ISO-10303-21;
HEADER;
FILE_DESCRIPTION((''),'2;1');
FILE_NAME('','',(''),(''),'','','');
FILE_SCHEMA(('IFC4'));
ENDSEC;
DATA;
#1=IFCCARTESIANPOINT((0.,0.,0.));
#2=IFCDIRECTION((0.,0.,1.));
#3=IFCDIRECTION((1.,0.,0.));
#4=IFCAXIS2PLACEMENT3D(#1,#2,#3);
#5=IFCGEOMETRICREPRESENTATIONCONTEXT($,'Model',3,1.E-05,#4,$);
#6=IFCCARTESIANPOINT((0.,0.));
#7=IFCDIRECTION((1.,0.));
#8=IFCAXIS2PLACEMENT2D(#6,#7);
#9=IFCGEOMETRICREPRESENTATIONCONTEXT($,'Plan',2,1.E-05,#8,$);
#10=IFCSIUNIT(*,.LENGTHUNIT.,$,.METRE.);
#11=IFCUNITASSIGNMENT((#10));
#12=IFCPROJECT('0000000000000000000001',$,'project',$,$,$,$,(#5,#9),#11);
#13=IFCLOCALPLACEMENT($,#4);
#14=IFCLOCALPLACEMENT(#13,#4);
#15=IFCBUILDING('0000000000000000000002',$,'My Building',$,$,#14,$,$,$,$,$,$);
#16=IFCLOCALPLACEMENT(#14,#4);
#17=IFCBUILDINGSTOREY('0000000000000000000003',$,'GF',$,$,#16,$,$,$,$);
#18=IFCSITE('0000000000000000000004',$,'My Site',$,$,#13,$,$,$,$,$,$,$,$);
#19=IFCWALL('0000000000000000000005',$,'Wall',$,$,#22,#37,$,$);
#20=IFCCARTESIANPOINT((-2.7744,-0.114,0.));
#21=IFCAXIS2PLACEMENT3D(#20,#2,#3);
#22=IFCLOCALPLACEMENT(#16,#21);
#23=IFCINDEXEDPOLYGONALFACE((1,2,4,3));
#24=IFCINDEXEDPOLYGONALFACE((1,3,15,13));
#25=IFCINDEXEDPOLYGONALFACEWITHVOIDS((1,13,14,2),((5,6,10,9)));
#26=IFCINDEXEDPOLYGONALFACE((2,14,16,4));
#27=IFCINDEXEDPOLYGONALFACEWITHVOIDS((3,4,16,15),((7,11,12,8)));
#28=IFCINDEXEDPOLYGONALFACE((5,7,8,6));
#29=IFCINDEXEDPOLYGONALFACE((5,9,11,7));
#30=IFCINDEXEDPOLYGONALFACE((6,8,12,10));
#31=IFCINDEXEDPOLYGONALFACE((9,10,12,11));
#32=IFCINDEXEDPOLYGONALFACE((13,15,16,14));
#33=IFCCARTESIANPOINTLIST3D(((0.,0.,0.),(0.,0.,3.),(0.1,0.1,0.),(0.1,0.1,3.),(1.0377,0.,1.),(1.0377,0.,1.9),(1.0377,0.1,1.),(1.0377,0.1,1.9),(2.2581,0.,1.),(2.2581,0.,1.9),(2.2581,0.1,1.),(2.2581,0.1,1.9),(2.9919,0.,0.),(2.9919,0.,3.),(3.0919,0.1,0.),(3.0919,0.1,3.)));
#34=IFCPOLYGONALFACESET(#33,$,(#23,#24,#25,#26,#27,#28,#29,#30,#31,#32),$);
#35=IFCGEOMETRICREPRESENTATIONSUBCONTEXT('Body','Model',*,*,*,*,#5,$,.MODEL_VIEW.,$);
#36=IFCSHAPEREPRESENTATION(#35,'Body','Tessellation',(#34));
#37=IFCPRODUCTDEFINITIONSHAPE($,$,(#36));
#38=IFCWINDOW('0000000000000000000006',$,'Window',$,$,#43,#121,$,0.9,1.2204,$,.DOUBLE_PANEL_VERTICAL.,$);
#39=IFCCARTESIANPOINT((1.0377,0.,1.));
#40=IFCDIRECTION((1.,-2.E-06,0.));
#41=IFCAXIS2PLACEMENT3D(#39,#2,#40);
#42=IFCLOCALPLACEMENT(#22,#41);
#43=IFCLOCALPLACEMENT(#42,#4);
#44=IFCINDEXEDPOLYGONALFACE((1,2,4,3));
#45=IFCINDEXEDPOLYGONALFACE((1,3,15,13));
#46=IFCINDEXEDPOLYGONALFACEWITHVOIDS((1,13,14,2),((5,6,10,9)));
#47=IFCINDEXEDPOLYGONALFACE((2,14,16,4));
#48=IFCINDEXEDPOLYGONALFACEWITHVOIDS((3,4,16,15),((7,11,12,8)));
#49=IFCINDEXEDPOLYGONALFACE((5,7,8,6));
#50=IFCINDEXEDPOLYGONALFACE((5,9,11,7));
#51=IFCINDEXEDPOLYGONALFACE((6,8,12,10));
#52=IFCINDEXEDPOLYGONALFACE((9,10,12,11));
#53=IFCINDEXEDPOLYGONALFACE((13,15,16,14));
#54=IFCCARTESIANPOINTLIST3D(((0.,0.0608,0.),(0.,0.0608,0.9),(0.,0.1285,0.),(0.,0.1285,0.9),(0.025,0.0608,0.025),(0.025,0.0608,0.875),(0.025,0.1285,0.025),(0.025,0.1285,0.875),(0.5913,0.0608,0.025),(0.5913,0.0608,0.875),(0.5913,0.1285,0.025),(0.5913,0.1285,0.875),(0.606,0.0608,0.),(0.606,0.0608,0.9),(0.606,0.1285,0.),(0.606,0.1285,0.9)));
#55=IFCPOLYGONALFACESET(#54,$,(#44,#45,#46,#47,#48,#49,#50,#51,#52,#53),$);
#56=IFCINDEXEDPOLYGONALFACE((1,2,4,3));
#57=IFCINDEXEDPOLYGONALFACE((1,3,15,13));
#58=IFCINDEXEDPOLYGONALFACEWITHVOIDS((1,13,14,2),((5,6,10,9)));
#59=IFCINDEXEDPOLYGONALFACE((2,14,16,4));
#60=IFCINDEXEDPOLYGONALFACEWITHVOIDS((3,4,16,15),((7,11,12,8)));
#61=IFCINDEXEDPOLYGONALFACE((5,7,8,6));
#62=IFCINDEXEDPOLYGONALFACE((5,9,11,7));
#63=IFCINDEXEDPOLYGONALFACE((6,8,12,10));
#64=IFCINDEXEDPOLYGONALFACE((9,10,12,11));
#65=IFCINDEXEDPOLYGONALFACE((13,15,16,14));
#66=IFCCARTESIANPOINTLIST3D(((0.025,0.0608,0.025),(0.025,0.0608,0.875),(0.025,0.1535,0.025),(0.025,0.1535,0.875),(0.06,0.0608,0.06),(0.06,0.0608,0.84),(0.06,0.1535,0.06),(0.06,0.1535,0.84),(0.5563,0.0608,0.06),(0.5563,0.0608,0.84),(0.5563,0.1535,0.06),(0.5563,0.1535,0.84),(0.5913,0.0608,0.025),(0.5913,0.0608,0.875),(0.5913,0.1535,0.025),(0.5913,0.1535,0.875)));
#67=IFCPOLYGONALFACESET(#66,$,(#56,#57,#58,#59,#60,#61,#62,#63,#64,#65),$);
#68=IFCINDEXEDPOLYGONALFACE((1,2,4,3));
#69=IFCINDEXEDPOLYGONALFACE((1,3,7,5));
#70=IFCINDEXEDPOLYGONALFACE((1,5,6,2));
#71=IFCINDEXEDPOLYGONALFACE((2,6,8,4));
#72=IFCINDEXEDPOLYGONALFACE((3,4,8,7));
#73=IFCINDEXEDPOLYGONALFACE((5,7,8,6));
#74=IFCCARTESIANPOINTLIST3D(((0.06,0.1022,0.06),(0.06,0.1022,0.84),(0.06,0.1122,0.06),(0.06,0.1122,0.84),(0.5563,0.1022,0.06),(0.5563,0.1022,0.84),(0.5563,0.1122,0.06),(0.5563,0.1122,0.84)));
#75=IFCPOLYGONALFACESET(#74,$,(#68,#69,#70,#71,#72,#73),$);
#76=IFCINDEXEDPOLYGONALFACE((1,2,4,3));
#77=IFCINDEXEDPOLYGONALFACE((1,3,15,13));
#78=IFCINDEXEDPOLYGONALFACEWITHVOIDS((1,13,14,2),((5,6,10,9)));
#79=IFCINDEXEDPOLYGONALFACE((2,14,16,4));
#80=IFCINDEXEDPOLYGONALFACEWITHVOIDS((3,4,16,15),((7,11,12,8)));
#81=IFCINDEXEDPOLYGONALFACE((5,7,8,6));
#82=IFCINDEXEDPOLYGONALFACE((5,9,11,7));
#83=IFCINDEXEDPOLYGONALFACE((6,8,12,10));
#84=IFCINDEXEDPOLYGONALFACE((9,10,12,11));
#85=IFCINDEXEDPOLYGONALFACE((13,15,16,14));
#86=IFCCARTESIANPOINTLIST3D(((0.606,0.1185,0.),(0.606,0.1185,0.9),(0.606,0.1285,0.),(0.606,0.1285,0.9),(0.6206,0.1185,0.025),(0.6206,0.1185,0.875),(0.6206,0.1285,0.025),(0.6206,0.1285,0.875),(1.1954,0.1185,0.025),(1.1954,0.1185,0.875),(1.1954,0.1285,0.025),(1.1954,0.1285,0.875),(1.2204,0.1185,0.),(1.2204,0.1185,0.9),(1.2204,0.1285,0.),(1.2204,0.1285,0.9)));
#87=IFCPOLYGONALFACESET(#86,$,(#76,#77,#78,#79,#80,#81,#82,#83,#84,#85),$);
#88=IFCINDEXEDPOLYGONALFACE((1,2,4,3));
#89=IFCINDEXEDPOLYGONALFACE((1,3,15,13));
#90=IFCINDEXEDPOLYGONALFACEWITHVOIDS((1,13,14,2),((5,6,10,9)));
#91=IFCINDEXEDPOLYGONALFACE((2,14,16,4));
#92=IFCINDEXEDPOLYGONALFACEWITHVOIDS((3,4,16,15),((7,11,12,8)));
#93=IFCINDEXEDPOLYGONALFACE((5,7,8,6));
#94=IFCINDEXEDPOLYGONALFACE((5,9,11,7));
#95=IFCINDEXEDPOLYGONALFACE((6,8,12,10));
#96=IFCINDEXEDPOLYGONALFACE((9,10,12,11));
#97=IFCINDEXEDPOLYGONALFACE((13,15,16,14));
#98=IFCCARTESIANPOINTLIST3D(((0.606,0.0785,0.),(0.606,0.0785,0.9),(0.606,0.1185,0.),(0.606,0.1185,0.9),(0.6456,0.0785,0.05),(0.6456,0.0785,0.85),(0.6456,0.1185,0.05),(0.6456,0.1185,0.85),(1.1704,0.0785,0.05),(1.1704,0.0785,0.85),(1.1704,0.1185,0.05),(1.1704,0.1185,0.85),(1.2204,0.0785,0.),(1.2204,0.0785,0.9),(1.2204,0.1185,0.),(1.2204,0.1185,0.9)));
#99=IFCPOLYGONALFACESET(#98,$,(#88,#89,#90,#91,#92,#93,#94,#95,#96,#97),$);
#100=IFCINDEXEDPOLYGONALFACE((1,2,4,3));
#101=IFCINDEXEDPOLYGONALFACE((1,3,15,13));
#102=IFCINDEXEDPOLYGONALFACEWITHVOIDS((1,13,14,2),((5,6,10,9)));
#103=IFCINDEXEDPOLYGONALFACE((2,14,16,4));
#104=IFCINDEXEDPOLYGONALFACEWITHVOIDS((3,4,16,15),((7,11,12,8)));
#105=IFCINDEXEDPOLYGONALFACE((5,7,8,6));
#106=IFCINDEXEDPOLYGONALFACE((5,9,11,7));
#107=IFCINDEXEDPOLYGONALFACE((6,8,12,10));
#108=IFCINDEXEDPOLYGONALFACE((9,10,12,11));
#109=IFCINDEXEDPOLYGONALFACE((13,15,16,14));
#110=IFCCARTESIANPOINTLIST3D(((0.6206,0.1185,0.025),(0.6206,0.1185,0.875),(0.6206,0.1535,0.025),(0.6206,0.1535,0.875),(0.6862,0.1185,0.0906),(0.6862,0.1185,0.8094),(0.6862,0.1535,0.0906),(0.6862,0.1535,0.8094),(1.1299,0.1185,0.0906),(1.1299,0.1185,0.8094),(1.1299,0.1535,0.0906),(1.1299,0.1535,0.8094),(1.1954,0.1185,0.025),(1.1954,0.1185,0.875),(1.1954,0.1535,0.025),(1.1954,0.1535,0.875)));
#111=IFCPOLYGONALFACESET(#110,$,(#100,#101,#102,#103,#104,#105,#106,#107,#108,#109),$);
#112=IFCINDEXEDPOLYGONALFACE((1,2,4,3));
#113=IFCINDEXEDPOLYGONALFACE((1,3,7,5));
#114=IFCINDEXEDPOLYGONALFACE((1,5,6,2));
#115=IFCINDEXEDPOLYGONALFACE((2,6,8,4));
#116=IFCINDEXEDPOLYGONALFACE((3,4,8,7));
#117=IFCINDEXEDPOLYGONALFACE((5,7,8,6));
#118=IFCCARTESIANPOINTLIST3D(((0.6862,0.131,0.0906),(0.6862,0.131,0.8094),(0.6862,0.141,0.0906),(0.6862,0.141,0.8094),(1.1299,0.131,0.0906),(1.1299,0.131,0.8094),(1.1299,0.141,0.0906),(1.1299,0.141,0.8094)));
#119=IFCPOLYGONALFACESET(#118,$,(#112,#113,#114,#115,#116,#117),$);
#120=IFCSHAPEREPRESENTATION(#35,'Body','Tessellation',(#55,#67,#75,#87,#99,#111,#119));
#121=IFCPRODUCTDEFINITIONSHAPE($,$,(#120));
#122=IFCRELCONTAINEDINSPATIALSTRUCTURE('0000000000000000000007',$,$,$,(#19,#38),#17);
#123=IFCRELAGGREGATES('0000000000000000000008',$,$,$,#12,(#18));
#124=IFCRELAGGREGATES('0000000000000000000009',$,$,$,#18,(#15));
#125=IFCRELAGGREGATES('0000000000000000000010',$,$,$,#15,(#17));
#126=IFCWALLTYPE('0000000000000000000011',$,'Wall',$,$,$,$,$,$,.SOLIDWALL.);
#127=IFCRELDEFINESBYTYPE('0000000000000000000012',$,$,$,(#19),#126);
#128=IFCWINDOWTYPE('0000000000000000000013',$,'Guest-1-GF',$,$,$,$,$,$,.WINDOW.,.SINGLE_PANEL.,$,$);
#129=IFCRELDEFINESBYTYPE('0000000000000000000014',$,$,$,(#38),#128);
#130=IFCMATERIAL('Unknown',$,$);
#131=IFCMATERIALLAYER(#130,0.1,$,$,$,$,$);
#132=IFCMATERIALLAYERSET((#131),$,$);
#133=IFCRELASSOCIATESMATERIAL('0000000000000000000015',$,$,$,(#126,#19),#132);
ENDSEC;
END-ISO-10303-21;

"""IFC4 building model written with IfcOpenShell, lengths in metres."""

from ifc_helpers import new_model, entity, si_unit, frame, origin_with_axes, origin_2d_with_axis, place, context, subcontext, project, spatial, line, indexed_curve, outline, extrude, shape, source, transform, mapped, material, layer, layer_set, layer_usage, type_object, type_shapes, element, fill, save


model = new_model("IFC4")

# Units and contexts
model_context = context("Model", 3, precision=1e-05, world=origin_with_axes())
plan_context = context("Plan", 2, precision=1e-05, world=origin_2d_with_axis())
body_context_1 = subcontext(model_context, "Body", "Model", "MODEL_VIEW")
body_context_2 = subcontext(plan_context, "Body", "Plan", "PLAN_VIEW")
ifc_project = project(units=[si_unit("LENGTHUNIT", "METRE")], contexts=[model_context, plan_context])

# Site, building, storey
site_placement = place(None, origin_with_axes())
site = spatial("IfcSite", under=ifc_project, at=site_placement, Name="My Site")
building_placement = place(site_placement, origin_with_axes())
building = spatial("IfcBuilding", under=site, at=building_placement, Name="My Building")
storey_placement = place(building_placement, origin_with_axes())
storey = spatial("IfcBuildingStorey", under=building, at=storey_placement, Name="GF")

# Shared definitions
ifc_material = material(Name="Unknown")

# Shared definitions
ifc_layer_1 = layer(ifc_material, 0.1)
ifc_layer_set_1 = layer_set([ifc_layer_1])
wall_type = type_object("IfcWallType", Name="Wall", PredefinedType="SOLIDWALL", material=ifc_layer_set_1)

# Wall, opening, window
ifc_layer_usage_1 = layer_usage(ifc_layer_set_1, "AXIS2", "POSITIVE", 0.0)
wall_1_placement = place(storey_placement, frame((-2.7744, -0.114, 0.0), z_axis=(0.0, 0.0, 1.0), x_axis=(1.0, 0.0, 0.0)))
wall_1 = element("IfcWall", 1, at=wall_1_placement, inside=storey, type_object=wall_type, material=ifc_layer_usage_1, Name="Wall", context=body_context_1, shape_type="SweptSolid", body=[
    extrude(outline(indexed_curve([(0.0, 0.0), (0.1, 0.1), (3.0919, 0.1), (2.9919, 0.0)], segments=[line(1, 2, 3, 4, 1)])), origin_with_axes(), (0.0, 0.0, 1.0), 3.0),
])
shared_shape_1 = source(origin_with_axes(), body_context_1, "Body", "SweptSolid", [
    extrude(outline(indexed_curve([(0.0, 0.0), (1.2204, 0.0), (1.2204, 0.9), (0.0, 0.9)], segments=[line(1, 2, 3, 4, 1)])), frame((0.0, -0.6, 0.0), z_axis=(0.0, -1.0, 0.0), x_axis=(1.0, 0.0, 0.0)), (0.0, 0.0, -1.0), 1.2),
])
opening_1_placement = place(wall_1_placement, frame((1.0377, 0.0, 1.0), z_axis=(0.0, 0.0, 1.0), x_axis=(1.0, -0.000002, 0.0)))
opening_1 = element("IfcOpeningElement", 2, at=opening_1_placement, cuts=wall_1, PredefinedType="OPENING", context=body_context_1, shape_type="MappedRepresentation", body=[
    mapped(shared_shape_1, transform((0.0, 0.0, 0.0), x_axis=(1.0, 0.0, 0.0), y_axis=(0.0, 1.0, 0.0), z_axis=(0.0, 0.0, 1.0), scale=1.0)),
])
window_type_1 = type_object("IfcWindowType", Name="Guest-1-GF", PartitioningType="SINGLE_PANEL", PredefinedType="WINDOW")
shared_shape_2 = source(origin_with_axes(), body_context_1, "Body", "SweptSolid", [
    extrude(outline(indexed_curve([(0.0, 0.0), (0.606, 0.0), (0.606, 0.9), (0.0, 0.9)], segments=[line(1, 2, 3, 4, 1)]), holes=[indexed_curve([(0.025, 0.025), (0.5913, 0.025), (0.5913, 0.875), (0.025, 0.875)], segments=[line(1, 2, 3, 4, 1)])]), frame((0.0, 0.0608, 0.0), z_axis=(0.0, -1.0, 0.0), x_axis=(1.0, 0.0, 0.0)), (0.0, 0.0, -1.0), 0.0677),
    extrude(outline(indexed_curve([(0.0, 0.0), (0.606, 0.0), (0.606, 0.9), (0.0, 0.9)], segments=[line(1, 2, 3, 4, 1)]), holes=[indexed_curve([(0.05, 0.05), (0.5663, 0.05), (0.5663, 0.85), (0.05, 0.85)], segments=[line(1, 2, 3, 4, 1)])]), frame((0.0, 0.0785, 0.0), z_axis=(0.0, -1.0, 0.0), x_axis=(1.0, 0.0, 0.0)), (0.0, 0.0, -1.0), -0.0177),
    extrude(outline(indexed_curve([(0.0, 0.0), (0.5663, 0.0), (0.5663, 0.85), (0.0, 0.85)], segments=[line(1, 2, 3, 4, 1)]), holes=[indexed_curve([(0.035, 0.035), (0.5313, 0.035), (0.5313, 0.815), (0.035, 0.815)], segments=[line(1, 2, 3, 4, 1)])]), frame((0.025, 0.0608, 0.025), z_axis=(0.0, -1.0, 0.0), x_axis=(1.0, 0.0, 0.0)), (0.0, 0.0, -1.0), 0.0927),
    extrude(outline(indexed_curve([(0.035, 0.035), (0.5313, 0.035), (0.5313, 0.815), (0.035, 0.815)], segments=[line(1, 2, 3, 4, 1)])), frame((0.025, 0.1022, 0.025), z_axis=(0.0, -1.0, 0.0), x_axis=(1.0, 0.0, 0.0)), (0.0, 0.0, -1.0), 0.01),
    extrude(outline(indexed_curve([(0.0, 0.0), (0.6144, 0.0), (0.6144, 0.9), (0.0, 0.9)], segments=[line(1, 2, 3, 4, 1)]), holes=[indexed_curve([(0.0147, 0.025), (0.5894, 0.025), (0.5894, 0.875), (0.0147, 0.875)], segments=[line(1, 2, 3, 4, 1)])]), frame((0.606, 0.1185, 0.0), z_axis=(0.0, -1.0, 0.0), x_axis=(1.0, 0.0, 0.0)), (0.0, 0.0, -1.0), 0.01),
    extrude(outline(indexed_curve([(0.0, 0.0), (0.6144, 0.0), (0.6144, 0.9), (0.0, 0.9)], segments=[line(1, 2, 3, 4, 1)]), holes=[indexed_curve([(0.0397, 0.05), (0.5644, 0.05), (0.5644, 0.85), (0.0397, 0.85)], segments=[line(1, 2, 3, 4, 1)])]), frame((0.606, 0.0785, 0.0), z_axis=(0.0, -1.0, 0.0), x_axis=(1.0, 0.0, 0.0)), (0.0, 0.0, -1.0), 0.04),
    extrude(outline(indexed_curve([(0.0, 0.0), (0.5748, 0.0), (0.5748, 0.85), (0.0, 0.85)], segments=[line(1, 2, 3, 4, 1)]), holes=[indexed_curve([(0.0656, 0.0656), (0.5092, 0.0656), (0.5092, 0.7844), (0.0656, 0.7844)], segments=[line(1, 2, 3, 4, 1)])]), frame((0.6206, 0.1185, 0.025), z_axis=(0.0, -1.0, 0.0), x_axis=(1.0, 0.0, 0.0)), (0.0, 0.0, -1.0), 0.035),
    extrude(outline(indexed_curve([(0.0656, 0.0656), (0.5092, 0.0656), (0.5092, 0.7844), (0.0656, 0.7844)], segments=[line(1, 2, 3, 4, 1)])), frame((0.6206, 0.131, 0.025), z_axis=(0.0, -1.0, 0.0), x_axis=(1.0, 0.0, 0.0)), (0.0, 0.0, -1.0), 0.01),
])
shared_shape_3 = source(origin_with_axes(), body_context_2, "Body", "Curve2D", [
    entity("IfcIndexedPolyCurve", entity("IfcCartesianPointList2D", [[0.05, 0.0785], [0.5663, 0.0785]])),
    entity("IfcIndexedPolyCurve", entity("IfcCartesianPointList2D", [[0.0, 0.1285], [0.025, 0.1285], [0.025, 0.0608], [0.05, 0.0608], [0.05, 0.0785], [0.0, 0.0785]]), [entity("IfcLineIndex", [1, 2, 3, 4, 5, 6, 1])]),
    entity("IfcIndexedPolyCurve", entity("IfcCartesianPointList2D", [[0.606, 0.1285], [0.5913, 0.1285], [0.5913, 0.0608], [0.5663, 0.0608], [0.5663, 0.0785], [0.606, 0.0785]])),
    entity("IfcIndexedPolyCurve", entity("IfcCartesianPointList2D", [[0.025, 0.0608], [0.06, 0.0608], [0.06, 0.1535], [0.025, 0.1535]]), [entity("IfcLineIndex", [1, 2, 3, 4, 1])]),
    entity("IfcIndexedPolyCurve", entity("IfcCartesianPointList2D", [[0.5913, 0.0608], [0.5563, 0.0608], [0.5563, 0.1535], [0.5913, 0.1535]]), [entity("IfcLineIndex", [1, 2, 3, 4, 1])]),
    entity("IfcIndexedPolyCurve", entity("IfcCartesianPointList2D", [[0.06, 0.0608], [0.5563, 0.0608]])),
    entity("IfcIndexedPolyCurve", entity("IfcCartesianPointList2D", [[0.06, 0.1535], [0.5563, 0.1535]])),
    entity("IfcIndexedPolyCurve", entity("IfcCartesianPointList2D", [[0.06, 0.1072], [0.5563, 0.1072]])),
    entity("IfcIndexedPolyCurve", entity("IfcCartesianPointList2D", [[0.6456, 0.0785], [1.1704, 0.0785]])),
    entity("IfcIndexedPolyCurve", entity("IfcCartesianPointList2D", [[0.606, 0.1285], [0.6206, 0.1285], [0.6206, 0.1185], [0.6456, 0.1185], [0.6456, 0.0785], [0.606, 0.0785]])),
    entity("IfcIndexedPolyCurve", entity("IfcCartesianPointList2D", [[1.2204, 0.1285], [1.1954, 0.1285], [1.1954, 0.1185], [1.1704, 0.1185], [1.1704, 0.0785], [1.2204, 0.0785]]), [entity("IfcLineIndex", [1, 2, 3, 4, 5, 6, 1])]),
    entity("IfcIndexedPolyCurve", entity("IfcCartesianPointList2D", [[0.6206, 0.1185], [0.6862, 0.1185], [0.6862, 0.1535], [0.6206, 0.1535]]), [entity("IfcLineIndex", [1, 2, 3, 4, 1])]),
    entity("IfcIndexedPolyCurve", entity("IfcCartesianPointList2D", [[1.1954, 0.1185], [1.1299, 0.1185], [1.1299, 0.1535], [1.1954, 0.1535]]), [entity("IfcLineIndex", [1, 2, 3, 4, 1])]),
    entity("IfcIndexedPolyCurve", entity("IfcCartesianPointList2D", [[0.6862, 0.1185], [1.1299, 0.1185]])),
    entity("IfcIndexedPolyCurve", entity("IfcCartesianPointList2D", [[0.6862, 0.1535], [1.1299, 0.1535]])),
    entity("IfcIndexedPolyCurve", entity("IfcCartesianPointList2D", [[0.6862, 0.136], [1.1299, 0.136]])),
])
type_shapes(window_type_1, [shared_shape_2, shared_shape_3])
window_1_placement = place(opening_1_placement, frame((0.0, 0.0, 0.0), z_axis=(0.0, 0.0, 1.0), x_axis=(1.0, 0.0, 0.0)))
window_1 = element("IfcWindow", 3, at=window_1_placement, inside=storey, type_object=window_type_1, Name="Window", OverallHeight=0.9, OverallWidth=1.2204, PartitioningType="DOUBLE_PANEL_VERTICAL", shapes=[
    shape(body_context_1, "Body", "MappedRepresentation", [mapped(shared_shape_2, transform((0.0, 0.0, 0.0), x_axis=(1.0, 0.0, 0.0), y_axis=(0.0, 1.0, 0.0), z_axis=(0.0, 0.0, 1.0), scale=1.0))]),
    shape(body_context_2, "Body", "MappedRepresentation", [mapped(shared_shape_3, transform((0.0, 0.0, 0.0), x_axis=(1.0, 0.0, 0.0), y_axis=(0.0, 1.0, 0.0), z_axis=(0.0, 0.0, 1.0), scale=1.0))]),
])
fill(opening_1, window_1)

save(model, "model.ifc")
